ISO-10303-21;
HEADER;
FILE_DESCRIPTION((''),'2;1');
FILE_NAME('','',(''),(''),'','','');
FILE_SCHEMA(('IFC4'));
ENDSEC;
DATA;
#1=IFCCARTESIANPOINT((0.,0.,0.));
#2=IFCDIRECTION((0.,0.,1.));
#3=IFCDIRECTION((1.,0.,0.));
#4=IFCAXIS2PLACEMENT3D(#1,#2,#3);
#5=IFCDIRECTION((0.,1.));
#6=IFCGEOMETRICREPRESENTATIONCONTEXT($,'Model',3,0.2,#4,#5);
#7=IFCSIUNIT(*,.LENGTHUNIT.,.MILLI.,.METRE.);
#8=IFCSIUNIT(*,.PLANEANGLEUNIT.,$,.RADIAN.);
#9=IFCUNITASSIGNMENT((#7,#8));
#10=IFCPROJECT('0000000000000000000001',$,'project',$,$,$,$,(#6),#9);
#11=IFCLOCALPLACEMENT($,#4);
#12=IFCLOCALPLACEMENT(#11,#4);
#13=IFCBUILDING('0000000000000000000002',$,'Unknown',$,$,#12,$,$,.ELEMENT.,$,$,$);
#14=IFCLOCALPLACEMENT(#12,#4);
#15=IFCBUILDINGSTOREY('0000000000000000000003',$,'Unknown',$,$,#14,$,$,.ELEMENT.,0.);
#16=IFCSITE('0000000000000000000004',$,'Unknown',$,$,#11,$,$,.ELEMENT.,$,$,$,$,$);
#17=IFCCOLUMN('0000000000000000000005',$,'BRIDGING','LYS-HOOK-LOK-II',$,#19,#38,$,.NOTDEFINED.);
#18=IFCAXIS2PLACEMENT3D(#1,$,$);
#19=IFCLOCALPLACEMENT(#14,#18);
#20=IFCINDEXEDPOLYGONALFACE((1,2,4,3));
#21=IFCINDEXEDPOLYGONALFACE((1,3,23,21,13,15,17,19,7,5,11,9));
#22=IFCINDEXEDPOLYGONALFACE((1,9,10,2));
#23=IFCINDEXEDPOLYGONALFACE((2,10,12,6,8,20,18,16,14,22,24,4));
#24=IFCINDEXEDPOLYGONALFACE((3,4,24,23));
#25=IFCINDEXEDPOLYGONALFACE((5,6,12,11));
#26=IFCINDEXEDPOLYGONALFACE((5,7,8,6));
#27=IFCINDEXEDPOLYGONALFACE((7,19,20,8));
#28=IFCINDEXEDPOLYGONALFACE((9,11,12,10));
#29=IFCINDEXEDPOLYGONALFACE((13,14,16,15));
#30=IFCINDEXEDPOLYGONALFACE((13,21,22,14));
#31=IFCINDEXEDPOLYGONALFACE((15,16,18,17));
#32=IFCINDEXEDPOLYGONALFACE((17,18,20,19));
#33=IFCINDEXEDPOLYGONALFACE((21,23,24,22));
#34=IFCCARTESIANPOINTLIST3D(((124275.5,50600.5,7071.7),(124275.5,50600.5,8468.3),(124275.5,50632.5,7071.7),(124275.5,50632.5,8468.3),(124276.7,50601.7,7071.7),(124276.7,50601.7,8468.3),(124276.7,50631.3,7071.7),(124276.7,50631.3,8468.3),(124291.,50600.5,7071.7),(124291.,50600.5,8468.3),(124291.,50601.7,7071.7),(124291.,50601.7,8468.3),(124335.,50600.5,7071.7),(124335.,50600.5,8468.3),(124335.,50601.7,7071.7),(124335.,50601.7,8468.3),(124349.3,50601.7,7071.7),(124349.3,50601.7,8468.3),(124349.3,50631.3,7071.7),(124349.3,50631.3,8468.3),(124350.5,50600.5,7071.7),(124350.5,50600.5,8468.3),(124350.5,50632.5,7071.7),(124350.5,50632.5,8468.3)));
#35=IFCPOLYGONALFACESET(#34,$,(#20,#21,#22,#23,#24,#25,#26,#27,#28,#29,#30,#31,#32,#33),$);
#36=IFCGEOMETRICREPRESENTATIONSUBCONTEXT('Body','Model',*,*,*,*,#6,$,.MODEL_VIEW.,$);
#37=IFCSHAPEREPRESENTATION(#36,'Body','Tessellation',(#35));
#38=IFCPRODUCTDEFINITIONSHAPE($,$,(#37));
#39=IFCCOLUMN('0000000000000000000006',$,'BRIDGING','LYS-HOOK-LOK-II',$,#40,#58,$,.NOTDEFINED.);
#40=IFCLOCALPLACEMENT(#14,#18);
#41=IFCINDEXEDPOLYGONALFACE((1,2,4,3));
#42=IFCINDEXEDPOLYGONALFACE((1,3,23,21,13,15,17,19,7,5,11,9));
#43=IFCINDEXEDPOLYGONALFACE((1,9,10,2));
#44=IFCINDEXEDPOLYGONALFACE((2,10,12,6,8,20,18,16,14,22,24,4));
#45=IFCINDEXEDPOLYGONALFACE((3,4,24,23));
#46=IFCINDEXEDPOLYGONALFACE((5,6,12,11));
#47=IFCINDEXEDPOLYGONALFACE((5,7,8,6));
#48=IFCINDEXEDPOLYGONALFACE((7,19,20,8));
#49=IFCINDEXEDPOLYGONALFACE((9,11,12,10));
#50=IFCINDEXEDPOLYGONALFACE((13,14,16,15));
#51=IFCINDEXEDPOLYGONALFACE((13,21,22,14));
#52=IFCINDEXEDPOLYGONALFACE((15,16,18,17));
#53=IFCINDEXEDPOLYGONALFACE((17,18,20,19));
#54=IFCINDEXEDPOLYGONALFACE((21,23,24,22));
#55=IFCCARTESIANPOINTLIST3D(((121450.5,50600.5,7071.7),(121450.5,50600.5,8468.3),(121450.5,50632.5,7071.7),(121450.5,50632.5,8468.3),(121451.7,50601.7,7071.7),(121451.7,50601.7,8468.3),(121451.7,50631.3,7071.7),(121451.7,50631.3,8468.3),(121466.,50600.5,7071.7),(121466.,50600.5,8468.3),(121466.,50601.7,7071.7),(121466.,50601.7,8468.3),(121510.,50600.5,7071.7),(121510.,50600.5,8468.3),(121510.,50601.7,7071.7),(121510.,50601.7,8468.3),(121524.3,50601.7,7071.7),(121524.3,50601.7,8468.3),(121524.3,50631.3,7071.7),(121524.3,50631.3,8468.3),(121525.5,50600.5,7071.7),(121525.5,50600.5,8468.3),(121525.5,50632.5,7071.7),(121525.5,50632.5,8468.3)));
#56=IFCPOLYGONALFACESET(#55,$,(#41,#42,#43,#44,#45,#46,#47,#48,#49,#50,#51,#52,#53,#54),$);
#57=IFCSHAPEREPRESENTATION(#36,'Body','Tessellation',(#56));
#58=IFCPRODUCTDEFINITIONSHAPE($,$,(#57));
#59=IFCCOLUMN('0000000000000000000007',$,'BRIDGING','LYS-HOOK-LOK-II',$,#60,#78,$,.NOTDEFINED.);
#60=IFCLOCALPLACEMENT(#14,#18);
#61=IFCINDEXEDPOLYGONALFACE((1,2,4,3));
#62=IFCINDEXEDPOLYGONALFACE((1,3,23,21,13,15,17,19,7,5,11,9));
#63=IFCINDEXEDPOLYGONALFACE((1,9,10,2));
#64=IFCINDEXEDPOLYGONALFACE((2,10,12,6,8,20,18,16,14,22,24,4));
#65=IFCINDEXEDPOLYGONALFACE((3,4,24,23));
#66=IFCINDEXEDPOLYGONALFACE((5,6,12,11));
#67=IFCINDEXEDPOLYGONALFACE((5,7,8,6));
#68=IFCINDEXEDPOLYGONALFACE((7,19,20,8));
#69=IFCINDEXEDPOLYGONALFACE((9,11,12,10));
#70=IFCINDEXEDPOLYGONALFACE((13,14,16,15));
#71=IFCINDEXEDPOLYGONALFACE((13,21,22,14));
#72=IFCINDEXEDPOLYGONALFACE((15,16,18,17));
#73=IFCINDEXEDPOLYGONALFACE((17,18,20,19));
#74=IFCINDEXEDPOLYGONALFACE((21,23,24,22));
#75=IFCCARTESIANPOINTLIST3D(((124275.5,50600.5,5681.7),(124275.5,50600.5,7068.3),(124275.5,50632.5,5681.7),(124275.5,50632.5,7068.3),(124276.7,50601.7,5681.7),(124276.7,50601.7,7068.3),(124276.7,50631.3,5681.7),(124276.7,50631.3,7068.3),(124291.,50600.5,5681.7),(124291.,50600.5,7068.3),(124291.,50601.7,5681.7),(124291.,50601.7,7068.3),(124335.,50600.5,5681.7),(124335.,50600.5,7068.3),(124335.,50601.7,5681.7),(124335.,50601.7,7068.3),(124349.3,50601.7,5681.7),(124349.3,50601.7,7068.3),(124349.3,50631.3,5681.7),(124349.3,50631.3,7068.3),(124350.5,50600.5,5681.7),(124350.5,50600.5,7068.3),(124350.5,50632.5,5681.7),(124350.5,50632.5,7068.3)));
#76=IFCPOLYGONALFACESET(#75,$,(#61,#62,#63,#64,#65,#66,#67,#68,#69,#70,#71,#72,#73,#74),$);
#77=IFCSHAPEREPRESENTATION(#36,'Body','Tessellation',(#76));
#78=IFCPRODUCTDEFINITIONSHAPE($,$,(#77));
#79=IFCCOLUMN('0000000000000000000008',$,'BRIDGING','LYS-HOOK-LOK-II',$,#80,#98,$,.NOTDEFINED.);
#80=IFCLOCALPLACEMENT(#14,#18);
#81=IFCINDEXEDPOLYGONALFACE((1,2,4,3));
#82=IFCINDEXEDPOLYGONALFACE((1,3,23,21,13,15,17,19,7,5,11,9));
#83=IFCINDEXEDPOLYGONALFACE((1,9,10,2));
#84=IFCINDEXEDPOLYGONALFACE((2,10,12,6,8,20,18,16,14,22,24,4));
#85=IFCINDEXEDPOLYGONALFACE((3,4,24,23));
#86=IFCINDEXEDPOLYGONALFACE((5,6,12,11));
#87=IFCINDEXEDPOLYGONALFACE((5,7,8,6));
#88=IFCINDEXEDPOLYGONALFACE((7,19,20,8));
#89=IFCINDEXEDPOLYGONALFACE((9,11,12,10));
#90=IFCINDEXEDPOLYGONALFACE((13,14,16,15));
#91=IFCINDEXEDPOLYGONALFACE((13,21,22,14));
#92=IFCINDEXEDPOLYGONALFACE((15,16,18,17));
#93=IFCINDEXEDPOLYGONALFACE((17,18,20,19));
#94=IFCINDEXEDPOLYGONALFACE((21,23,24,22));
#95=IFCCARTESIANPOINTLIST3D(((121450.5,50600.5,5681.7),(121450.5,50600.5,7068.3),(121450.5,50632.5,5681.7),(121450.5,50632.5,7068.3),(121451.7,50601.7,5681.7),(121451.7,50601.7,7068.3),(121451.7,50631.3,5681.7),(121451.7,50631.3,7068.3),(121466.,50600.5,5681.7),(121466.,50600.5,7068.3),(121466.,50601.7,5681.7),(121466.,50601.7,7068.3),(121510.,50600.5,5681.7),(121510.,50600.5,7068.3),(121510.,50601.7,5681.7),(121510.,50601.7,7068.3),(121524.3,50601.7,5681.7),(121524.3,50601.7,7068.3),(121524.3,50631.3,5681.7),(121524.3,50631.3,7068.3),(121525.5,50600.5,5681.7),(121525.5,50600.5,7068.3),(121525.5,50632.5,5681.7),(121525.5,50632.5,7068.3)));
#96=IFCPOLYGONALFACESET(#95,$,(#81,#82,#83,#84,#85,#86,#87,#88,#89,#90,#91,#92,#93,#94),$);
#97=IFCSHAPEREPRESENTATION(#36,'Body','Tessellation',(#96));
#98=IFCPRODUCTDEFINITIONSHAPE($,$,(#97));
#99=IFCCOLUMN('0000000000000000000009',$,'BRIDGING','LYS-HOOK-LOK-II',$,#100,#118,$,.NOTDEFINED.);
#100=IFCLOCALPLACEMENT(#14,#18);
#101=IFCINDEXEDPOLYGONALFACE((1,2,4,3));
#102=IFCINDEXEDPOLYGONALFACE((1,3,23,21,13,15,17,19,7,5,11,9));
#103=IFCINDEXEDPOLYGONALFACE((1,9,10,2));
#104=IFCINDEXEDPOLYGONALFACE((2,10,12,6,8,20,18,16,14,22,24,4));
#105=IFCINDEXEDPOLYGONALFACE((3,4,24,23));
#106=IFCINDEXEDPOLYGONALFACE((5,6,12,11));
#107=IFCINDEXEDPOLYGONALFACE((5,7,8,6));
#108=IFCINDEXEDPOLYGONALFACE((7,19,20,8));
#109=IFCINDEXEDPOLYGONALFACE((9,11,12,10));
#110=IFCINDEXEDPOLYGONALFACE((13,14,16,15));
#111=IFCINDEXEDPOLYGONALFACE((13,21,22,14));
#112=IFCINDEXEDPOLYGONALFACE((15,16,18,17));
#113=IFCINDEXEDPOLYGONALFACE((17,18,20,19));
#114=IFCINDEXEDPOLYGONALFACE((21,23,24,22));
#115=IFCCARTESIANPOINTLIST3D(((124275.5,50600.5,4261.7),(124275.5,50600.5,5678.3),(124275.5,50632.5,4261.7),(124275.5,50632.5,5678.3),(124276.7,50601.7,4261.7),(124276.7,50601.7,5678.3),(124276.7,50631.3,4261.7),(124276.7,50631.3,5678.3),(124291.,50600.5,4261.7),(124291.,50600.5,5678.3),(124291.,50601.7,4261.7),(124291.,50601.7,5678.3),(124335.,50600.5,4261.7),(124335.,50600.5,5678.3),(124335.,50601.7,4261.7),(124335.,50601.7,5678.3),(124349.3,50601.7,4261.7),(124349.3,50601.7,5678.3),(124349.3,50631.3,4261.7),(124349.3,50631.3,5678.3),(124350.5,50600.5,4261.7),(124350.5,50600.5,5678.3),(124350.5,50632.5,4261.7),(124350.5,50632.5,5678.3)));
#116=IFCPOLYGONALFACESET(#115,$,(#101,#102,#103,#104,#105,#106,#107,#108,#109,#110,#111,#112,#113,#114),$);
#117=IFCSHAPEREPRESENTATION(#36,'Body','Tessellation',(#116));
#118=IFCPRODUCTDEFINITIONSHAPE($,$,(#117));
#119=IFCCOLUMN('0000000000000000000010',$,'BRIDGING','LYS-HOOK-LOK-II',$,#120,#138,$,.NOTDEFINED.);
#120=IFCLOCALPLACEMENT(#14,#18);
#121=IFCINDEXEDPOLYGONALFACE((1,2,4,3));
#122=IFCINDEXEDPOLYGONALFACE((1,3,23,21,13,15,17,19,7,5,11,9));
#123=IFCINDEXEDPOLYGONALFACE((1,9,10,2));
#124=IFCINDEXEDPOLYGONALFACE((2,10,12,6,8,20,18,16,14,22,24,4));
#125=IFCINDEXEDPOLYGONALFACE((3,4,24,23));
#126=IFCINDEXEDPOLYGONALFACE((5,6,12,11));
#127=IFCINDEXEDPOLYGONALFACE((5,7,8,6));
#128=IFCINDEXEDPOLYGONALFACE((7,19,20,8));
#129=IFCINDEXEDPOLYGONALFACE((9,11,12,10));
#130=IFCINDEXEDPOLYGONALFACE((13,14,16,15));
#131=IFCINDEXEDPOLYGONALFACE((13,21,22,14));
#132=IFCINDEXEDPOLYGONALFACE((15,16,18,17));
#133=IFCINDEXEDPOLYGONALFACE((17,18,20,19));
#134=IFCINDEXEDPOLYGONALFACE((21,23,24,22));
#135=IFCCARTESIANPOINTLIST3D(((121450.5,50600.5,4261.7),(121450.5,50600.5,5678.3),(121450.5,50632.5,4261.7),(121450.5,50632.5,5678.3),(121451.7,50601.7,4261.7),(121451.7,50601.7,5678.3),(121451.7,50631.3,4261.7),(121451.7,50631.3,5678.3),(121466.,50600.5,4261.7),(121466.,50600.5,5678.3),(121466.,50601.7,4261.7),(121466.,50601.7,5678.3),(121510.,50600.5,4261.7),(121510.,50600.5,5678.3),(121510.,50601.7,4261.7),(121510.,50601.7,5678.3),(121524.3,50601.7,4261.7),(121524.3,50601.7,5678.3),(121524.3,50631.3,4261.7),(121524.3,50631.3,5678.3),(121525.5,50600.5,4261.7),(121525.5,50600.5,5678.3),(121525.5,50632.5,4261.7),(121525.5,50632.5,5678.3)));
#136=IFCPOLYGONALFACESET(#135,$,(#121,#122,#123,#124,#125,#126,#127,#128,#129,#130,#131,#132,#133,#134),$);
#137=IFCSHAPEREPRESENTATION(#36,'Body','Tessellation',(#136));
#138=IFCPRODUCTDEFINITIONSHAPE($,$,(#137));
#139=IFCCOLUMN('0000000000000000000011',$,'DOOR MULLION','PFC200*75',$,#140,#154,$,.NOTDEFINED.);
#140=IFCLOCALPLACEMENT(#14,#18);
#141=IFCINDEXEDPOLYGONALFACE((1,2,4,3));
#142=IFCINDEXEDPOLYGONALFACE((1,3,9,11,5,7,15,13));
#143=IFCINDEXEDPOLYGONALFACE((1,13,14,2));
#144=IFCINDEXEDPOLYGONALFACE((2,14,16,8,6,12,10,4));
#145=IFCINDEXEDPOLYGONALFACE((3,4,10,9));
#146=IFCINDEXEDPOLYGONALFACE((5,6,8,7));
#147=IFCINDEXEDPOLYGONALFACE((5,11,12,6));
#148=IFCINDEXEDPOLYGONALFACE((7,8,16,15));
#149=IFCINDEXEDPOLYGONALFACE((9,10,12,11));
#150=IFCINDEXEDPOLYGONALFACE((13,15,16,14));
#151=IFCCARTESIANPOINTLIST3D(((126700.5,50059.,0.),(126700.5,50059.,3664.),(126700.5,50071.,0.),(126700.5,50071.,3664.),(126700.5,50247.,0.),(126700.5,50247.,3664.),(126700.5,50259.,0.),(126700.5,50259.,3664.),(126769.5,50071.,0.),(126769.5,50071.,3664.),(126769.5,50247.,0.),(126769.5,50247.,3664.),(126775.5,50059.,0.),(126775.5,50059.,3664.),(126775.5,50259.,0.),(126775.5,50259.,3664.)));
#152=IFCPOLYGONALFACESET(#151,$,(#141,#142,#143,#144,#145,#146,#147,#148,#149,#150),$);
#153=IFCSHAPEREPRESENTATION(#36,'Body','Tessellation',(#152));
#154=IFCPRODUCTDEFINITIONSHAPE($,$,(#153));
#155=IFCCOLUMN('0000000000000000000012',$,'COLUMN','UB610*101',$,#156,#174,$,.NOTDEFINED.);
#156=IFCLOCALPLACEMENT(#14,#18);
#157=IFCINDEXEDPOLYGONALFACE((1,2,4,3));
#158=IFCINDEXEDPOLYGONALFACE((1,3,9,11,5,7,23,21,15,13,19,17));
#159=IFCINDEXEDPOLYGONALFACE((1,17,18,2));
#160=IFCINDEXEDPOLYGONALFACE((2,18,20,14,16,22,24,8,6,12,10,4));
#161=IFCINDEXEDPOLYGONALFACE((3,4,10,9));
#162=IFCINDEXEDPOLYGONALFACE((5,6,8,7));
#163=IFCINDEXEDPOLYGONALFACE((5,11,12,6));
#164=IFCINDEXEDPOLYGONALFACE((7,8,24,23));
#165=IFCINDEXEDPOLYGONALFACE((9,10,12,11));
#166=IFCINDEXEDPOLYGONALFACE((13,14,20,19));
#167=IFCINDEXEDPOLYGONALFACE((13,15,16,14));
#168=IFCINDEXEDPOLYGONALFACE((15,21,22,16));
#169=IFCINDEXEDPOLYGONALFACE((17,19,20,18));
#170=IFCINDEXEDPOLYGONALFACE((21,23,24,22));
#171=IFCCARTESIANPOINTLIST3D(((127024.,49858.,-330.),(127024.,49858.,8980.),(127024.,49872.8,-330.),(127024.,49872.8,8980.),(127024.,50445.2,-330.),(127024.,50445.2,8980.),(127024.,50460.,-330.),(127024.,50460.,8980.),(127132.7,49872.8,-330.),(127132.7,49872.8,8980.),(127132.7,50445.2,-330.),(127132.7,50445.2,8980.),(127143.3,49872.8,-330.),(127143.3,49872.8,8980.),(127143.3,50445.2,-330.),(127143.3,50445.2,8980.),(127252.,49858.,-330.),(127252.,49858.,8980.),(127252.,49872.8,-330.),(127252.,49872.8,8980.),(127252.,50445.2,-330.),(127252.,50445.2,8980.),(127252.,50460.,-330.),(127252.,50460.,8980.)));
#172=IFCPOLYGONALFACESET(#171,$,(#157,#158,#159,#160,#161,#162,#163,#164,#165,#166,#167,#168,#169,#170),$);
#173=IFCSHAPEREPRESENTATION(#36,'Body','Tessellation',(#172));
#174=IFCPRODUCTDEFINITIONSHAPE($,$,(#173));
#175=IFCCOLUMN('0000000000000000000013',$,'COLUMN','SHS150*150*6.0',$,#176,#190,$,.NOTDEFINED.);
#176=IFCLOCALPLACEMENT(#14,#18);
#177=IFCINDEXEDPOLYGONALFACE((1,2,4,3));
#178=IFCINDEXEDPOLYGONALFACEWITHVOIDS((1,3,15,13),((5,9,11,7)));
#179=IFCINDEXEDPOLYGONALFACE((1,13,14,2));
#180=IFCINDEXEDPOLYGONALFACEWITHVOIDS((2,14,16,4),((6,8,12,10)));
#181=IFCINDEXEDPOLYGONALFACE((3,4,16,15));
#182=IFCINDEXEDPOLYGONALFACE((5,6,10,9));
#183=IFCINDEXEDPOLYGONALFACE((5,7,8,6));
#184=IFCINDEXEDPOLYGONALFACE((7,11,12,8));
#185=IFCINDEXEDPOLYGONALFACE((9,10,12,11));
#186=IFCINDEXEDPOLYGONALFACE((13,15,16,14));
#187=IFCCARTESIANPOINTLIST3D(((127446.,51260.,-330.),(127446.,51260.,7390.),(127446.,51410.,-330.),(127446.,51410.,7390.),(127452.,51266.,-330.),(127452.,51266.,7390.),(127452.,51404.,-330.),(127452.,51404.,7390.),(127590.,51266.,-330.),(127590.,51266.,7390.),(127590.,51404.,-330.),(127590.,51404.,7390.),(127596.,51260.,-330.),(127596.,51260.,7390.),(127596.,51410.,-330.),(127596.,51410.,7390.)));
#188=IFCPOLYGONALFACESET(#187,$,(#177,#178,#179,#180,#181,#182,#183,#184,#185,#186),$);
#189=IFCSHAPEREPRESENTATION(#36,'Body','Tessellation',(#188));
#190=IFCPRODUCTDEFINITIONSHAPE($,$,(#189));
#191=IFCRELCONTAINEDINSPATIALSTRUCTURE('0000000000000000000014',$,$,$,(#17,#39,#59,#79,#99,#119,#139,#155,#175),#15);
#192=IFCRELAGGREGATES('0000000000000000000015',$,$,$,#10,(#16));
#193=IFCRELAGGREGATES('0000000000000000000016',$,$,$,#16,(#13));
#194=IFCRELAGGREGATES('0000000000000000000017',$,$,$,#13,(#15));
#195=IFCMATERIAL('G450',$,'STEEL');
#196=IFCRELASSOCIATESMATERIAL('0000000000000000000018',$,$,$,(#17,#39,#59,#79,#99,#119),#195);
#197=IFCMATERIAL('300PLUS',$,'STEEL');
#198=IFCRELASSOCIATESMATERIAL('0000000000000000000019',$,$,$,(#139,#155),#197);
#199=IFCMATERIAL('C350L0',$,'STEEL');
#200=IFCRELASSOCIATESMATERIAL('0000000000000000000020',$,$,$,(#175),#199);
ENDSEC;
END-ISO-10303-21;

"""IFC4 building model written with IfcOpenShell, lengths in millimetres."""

from ifc_helpers import new_model, si_unit, direction, frame, origin_with_axes, place, context, subcontext, project, spatial, line, indexed_curve, outline, extrude, material, element, save


model = new_model("IFC4")

# Units and contexts
model_context = context("Model", 3, precision=0.2, world=origin_with_axes(), true_north=direction((0.0, 1.0)))
body_context = subcontext(model_context, "Body", "Model", "MODEL_VIEW")
ifc_project = project(units=[si_unit("LENGTHUNIT", "METRE", prefix="MILLI"), si_unit("PLANEANGLEUNIT", "RADIAN")], contexts=[model_context])

# Site, building, storey
site_placement = place(None, origin_with_axes())
site = spatial("IfcSite", under=ifc_project, at=site_placement, Name="Unknown", CompositionType="ELEMENT")
building_placement = place(site_placement, origin_with_axes())
building = spatial("IfcBuilding", under=site, at=building_placement, Name="Unknown", CompositionType="ELEMENT")
storey_placement = place(building_placement, origin_with_axes())
storey = spatial("IfcBuildingStorey", under=building, at=storey_placement, Name="Unknown", CompositionType="ELEMENT", Elevation=0.0)

# Columns
ifc_material_1 = material(Name="G450", Category="STEEL")
for number, where, z_axis, x_axis, name in (
    (1, (124313.0, 50616.5, 7071.7), (0.0, -1.0, 0.0), (0.0, 0.0, 1.0), "BRIDGING"),
    (2, (121488.0, 50616.5, 7071.7), (0.0, -1.0, 0.0), (0.0, 0.0, 1.0), "BRIDGING"),
):
    element("IfcColumn", number, at=place(storey_placement, frame(where, z_axis=z_axis, x_axis=x_axis)), inside=storey, material=ifc_material_1, Name=name, Description="LYS-HOOK-LOK-II", PredefinedType="NOTDEFINED", context=body_context, shape_type="SolidModel", body=[
        extrude(outline(indexed_curve([(16.0, -37.5), (16.0, -22.0), (14.8, -22.0), (14.8, -36.3), (-14.8, -36.3), (-14.8, 36.3), (14.8, 36.3), (14.8, 22.0), (16.0, 22.0), (16.0, 37.5), (-16.0, 37.5), (-16.0, -37.5)], segments=[line(1, 2, 3, 4, 5, 6, 7, 8, 9, 10, 11, 12, 1)])), frame((0.0, 0.0, 0.0), z_axis=(-1.0, 0.0, 0.0), x_axis=(0.0, 0.0, 1.0)), (0.0, 0.0, -1.0), 1396.6),
    ])
for number, where, z_axis, x_axis, name in (
    (3, (124313.0, 50616.5, 5681.7), (0.0, -1.0, 0.0), (0.0, 0.0, 1.0), "BRIDGING"),
    (4, (121488.0, 50616.5, 5681.7), (0.0, -1.0, 0.0), (0.0, 0.0, 1.0), "BRIDGING"),
):
    element("IfcColumn", number, at=place(storey_placement, frame(where, z_axis=z_axis, x_axis=x_axis)), inside=storey, material=ifc_material_1, Name=name, Description="LYS-HOOK-LOK-II", PredefinedType="NOTDEFINED", context=body_context, shape_type="SolidModel", body=[
        extrude(outline(indexed_curve([(16.0, -37.5), (16.0, -22.0), (14.8, -22.0), (14.8, -36.3), (-14.8, -36.3), (-14.8, 36.3), (14.8, 36.3), (14.8, 22.0), (16.0, 22.0), (16.0, 37.5), (-16.0, 37.5), (-16.0, -37.5)], segments=[line(1, 2, 3, 4, 5, 6, 7, 8, 9, 10, 11, 12, 1)])), frame((0.0, 0.0, 0.0), z_axis=(-1.0, 0.0, 0.0), x_axis=(0.0, 0.0, 1.0)), (0.0, 0.0, -1.0), 1386.6),
    ])
for number, where, z_axis, x_axis, name in (
    (5, (124313.0, 50616.5, 4261.7), (0.0, -1.0, 0.0), (0.0, 0.0, 1.0), "BRIDGING"),
    (6, (121488.0, 50616.5, 4261.7), (0.0, -1.0, 0.0), (0.0, 0.0, 1.0), "BRIDGING"),
):
    element("IfcColumn", number, at=place(storey_placement, frame(where, z_axis=z_axis, x_axis=x_axis)), inside=storey, material=ifc_material_1, Name=name, Description="LYS-HOOK-LOK-II", PredefinedType="NOTDEFINED", context=body_context, shape_type="SolidModel", body=[
        extrude(outline(indexed_curve([(16.0, -37.5), (16.0, -22.0), (14.8, -22.0), (14.8, -36.3), (-14.8, -36.3), (-14.8, 36.3), (14.8, 36.3), (14.8, 22.0), (16.0, 22.0), (16.0, 37.5), (-16.0, 37.5), (-16.0, -37.5)], segments=[line(1, 2, 3, 4, 5, 6, 7, 8, 9, 10, 11, 12, 1)])), frame((0.0, 0.0, 0.0), z_axis=(-1.0, 0.0, 0.0), x_axis=(0.0, 0.0, 1.0)), (0.0, 0.0, -1.0), 1416.6),
    ])
ifc_material_2 = material(Name="300PLUS", Category="STEEL")
column_1_placement = place(storey_placement, frame((126738.0, 50159.0, 0.0), z_axis=(-1.0, 0.0, 0.0), x_axis=(0.0, 0.0, 1.0)))
element("IfcColumn", 7, at=column_1_placement, inside=storey, material=ifc_material_2, Name="DOOR MULLION", Description="PFC200*75", PredefinedType="NOTDEFINED", context=body_context, shape_type="SolidModel", body=[
    extrude(outline(indexed_curve([(-37.5, -100.0), (37.5, -100.0), (37.5, -88.0), (-31.5, -88.0), (-31.5, 88.0), (37.5, 88.0), (37.5, 100.0), (-37.5, 100.0)], segments=[line(1, 2, 3, 4, 5, 6, 7, 8, 1)])), frame((0.0, 0.0, 0.0), z_axis=(-1.0, 0.0, 0.0), x_axis=(0.0, 0.0, 1.0)), (0.0, 0.0, -1.0), 3664.0),
])
column_2_placement = place(storey_placement, frame((127138.0, 50159.0, -330.0), z_axis=(-1.0, 0.0, 0.0), x_axis=(0.0, 0.0, 1.0)))
element("IfcColumn", 8, at=column_2_placement, inside=storey, material=ifc_material_2, Name="COLUMN", Description="UB610*101", PredefinedType="NOTDEFINED", context=body_context, shape_type="SolidModel", body=[
    extrude(outline(indexed_curve([(-114.0, -301.0), (114.0, -301.0), (114.0, -286.2), (5.3, -286.2), (5.3, 286.2), (114.0, 286.2), (114.0, 301.0), (-114.0, 301.0), (-114.0, 286.2), (-5.3, 286.2), (-5.3, -286.2), (-114.0, -286.2)], segments=[line(1, 2, 3, 4, 5, 6, 7, 8, 9, 10, 11, 12, 1)])), frame((0.0, 0.0, 0.0), z_axis=(-1.0, 0.0, 0.0), x_axis=(0.0, 0.0, 1.0)), (0.0, 0.0, -1.0), 9310.0),
])
ifc_material_3 = material(Name="C350L0", Category="STEEL")
column_3_placement = place(storey_placement, frame((127521.0, 51335.0, -330.0), z_axis=(-1.0, 0.0, 0.0), x_axis=(0.0, 0.0, 1.0)))
element("IfcColumn", 9, at=column_3_placement, inside=storey, material=ifc_material_3, Name="COLUMN", Description="SHS150*150*6.0", PredefinedType="NOTDEFINED", context=body_context, shape_type="SolidModel", body=[
    extrude(outline(indexed_curve([(-75.0, -75.0), (75.0, -75.0), (75.0, 75.0), (-75.0, 75.0)], segments=[line(1, 2, 3, 4, 1)]), holes=[indexed_curve([(-69.0, -69.0), (-69.0, 69.0), (69.0, 69.0), (69.0, -69.0)], segments=[line(1, 2, 3, 4, 1)])]), frame((0.0, 0.0, 0.0), z_axis=(-1.0, 0.0, 0.0), x_axis=(0.0, 0.0, 1.0)), (0.0, 0.0, -1.0), 7720.0),
])

save(model, "model.ifc")
